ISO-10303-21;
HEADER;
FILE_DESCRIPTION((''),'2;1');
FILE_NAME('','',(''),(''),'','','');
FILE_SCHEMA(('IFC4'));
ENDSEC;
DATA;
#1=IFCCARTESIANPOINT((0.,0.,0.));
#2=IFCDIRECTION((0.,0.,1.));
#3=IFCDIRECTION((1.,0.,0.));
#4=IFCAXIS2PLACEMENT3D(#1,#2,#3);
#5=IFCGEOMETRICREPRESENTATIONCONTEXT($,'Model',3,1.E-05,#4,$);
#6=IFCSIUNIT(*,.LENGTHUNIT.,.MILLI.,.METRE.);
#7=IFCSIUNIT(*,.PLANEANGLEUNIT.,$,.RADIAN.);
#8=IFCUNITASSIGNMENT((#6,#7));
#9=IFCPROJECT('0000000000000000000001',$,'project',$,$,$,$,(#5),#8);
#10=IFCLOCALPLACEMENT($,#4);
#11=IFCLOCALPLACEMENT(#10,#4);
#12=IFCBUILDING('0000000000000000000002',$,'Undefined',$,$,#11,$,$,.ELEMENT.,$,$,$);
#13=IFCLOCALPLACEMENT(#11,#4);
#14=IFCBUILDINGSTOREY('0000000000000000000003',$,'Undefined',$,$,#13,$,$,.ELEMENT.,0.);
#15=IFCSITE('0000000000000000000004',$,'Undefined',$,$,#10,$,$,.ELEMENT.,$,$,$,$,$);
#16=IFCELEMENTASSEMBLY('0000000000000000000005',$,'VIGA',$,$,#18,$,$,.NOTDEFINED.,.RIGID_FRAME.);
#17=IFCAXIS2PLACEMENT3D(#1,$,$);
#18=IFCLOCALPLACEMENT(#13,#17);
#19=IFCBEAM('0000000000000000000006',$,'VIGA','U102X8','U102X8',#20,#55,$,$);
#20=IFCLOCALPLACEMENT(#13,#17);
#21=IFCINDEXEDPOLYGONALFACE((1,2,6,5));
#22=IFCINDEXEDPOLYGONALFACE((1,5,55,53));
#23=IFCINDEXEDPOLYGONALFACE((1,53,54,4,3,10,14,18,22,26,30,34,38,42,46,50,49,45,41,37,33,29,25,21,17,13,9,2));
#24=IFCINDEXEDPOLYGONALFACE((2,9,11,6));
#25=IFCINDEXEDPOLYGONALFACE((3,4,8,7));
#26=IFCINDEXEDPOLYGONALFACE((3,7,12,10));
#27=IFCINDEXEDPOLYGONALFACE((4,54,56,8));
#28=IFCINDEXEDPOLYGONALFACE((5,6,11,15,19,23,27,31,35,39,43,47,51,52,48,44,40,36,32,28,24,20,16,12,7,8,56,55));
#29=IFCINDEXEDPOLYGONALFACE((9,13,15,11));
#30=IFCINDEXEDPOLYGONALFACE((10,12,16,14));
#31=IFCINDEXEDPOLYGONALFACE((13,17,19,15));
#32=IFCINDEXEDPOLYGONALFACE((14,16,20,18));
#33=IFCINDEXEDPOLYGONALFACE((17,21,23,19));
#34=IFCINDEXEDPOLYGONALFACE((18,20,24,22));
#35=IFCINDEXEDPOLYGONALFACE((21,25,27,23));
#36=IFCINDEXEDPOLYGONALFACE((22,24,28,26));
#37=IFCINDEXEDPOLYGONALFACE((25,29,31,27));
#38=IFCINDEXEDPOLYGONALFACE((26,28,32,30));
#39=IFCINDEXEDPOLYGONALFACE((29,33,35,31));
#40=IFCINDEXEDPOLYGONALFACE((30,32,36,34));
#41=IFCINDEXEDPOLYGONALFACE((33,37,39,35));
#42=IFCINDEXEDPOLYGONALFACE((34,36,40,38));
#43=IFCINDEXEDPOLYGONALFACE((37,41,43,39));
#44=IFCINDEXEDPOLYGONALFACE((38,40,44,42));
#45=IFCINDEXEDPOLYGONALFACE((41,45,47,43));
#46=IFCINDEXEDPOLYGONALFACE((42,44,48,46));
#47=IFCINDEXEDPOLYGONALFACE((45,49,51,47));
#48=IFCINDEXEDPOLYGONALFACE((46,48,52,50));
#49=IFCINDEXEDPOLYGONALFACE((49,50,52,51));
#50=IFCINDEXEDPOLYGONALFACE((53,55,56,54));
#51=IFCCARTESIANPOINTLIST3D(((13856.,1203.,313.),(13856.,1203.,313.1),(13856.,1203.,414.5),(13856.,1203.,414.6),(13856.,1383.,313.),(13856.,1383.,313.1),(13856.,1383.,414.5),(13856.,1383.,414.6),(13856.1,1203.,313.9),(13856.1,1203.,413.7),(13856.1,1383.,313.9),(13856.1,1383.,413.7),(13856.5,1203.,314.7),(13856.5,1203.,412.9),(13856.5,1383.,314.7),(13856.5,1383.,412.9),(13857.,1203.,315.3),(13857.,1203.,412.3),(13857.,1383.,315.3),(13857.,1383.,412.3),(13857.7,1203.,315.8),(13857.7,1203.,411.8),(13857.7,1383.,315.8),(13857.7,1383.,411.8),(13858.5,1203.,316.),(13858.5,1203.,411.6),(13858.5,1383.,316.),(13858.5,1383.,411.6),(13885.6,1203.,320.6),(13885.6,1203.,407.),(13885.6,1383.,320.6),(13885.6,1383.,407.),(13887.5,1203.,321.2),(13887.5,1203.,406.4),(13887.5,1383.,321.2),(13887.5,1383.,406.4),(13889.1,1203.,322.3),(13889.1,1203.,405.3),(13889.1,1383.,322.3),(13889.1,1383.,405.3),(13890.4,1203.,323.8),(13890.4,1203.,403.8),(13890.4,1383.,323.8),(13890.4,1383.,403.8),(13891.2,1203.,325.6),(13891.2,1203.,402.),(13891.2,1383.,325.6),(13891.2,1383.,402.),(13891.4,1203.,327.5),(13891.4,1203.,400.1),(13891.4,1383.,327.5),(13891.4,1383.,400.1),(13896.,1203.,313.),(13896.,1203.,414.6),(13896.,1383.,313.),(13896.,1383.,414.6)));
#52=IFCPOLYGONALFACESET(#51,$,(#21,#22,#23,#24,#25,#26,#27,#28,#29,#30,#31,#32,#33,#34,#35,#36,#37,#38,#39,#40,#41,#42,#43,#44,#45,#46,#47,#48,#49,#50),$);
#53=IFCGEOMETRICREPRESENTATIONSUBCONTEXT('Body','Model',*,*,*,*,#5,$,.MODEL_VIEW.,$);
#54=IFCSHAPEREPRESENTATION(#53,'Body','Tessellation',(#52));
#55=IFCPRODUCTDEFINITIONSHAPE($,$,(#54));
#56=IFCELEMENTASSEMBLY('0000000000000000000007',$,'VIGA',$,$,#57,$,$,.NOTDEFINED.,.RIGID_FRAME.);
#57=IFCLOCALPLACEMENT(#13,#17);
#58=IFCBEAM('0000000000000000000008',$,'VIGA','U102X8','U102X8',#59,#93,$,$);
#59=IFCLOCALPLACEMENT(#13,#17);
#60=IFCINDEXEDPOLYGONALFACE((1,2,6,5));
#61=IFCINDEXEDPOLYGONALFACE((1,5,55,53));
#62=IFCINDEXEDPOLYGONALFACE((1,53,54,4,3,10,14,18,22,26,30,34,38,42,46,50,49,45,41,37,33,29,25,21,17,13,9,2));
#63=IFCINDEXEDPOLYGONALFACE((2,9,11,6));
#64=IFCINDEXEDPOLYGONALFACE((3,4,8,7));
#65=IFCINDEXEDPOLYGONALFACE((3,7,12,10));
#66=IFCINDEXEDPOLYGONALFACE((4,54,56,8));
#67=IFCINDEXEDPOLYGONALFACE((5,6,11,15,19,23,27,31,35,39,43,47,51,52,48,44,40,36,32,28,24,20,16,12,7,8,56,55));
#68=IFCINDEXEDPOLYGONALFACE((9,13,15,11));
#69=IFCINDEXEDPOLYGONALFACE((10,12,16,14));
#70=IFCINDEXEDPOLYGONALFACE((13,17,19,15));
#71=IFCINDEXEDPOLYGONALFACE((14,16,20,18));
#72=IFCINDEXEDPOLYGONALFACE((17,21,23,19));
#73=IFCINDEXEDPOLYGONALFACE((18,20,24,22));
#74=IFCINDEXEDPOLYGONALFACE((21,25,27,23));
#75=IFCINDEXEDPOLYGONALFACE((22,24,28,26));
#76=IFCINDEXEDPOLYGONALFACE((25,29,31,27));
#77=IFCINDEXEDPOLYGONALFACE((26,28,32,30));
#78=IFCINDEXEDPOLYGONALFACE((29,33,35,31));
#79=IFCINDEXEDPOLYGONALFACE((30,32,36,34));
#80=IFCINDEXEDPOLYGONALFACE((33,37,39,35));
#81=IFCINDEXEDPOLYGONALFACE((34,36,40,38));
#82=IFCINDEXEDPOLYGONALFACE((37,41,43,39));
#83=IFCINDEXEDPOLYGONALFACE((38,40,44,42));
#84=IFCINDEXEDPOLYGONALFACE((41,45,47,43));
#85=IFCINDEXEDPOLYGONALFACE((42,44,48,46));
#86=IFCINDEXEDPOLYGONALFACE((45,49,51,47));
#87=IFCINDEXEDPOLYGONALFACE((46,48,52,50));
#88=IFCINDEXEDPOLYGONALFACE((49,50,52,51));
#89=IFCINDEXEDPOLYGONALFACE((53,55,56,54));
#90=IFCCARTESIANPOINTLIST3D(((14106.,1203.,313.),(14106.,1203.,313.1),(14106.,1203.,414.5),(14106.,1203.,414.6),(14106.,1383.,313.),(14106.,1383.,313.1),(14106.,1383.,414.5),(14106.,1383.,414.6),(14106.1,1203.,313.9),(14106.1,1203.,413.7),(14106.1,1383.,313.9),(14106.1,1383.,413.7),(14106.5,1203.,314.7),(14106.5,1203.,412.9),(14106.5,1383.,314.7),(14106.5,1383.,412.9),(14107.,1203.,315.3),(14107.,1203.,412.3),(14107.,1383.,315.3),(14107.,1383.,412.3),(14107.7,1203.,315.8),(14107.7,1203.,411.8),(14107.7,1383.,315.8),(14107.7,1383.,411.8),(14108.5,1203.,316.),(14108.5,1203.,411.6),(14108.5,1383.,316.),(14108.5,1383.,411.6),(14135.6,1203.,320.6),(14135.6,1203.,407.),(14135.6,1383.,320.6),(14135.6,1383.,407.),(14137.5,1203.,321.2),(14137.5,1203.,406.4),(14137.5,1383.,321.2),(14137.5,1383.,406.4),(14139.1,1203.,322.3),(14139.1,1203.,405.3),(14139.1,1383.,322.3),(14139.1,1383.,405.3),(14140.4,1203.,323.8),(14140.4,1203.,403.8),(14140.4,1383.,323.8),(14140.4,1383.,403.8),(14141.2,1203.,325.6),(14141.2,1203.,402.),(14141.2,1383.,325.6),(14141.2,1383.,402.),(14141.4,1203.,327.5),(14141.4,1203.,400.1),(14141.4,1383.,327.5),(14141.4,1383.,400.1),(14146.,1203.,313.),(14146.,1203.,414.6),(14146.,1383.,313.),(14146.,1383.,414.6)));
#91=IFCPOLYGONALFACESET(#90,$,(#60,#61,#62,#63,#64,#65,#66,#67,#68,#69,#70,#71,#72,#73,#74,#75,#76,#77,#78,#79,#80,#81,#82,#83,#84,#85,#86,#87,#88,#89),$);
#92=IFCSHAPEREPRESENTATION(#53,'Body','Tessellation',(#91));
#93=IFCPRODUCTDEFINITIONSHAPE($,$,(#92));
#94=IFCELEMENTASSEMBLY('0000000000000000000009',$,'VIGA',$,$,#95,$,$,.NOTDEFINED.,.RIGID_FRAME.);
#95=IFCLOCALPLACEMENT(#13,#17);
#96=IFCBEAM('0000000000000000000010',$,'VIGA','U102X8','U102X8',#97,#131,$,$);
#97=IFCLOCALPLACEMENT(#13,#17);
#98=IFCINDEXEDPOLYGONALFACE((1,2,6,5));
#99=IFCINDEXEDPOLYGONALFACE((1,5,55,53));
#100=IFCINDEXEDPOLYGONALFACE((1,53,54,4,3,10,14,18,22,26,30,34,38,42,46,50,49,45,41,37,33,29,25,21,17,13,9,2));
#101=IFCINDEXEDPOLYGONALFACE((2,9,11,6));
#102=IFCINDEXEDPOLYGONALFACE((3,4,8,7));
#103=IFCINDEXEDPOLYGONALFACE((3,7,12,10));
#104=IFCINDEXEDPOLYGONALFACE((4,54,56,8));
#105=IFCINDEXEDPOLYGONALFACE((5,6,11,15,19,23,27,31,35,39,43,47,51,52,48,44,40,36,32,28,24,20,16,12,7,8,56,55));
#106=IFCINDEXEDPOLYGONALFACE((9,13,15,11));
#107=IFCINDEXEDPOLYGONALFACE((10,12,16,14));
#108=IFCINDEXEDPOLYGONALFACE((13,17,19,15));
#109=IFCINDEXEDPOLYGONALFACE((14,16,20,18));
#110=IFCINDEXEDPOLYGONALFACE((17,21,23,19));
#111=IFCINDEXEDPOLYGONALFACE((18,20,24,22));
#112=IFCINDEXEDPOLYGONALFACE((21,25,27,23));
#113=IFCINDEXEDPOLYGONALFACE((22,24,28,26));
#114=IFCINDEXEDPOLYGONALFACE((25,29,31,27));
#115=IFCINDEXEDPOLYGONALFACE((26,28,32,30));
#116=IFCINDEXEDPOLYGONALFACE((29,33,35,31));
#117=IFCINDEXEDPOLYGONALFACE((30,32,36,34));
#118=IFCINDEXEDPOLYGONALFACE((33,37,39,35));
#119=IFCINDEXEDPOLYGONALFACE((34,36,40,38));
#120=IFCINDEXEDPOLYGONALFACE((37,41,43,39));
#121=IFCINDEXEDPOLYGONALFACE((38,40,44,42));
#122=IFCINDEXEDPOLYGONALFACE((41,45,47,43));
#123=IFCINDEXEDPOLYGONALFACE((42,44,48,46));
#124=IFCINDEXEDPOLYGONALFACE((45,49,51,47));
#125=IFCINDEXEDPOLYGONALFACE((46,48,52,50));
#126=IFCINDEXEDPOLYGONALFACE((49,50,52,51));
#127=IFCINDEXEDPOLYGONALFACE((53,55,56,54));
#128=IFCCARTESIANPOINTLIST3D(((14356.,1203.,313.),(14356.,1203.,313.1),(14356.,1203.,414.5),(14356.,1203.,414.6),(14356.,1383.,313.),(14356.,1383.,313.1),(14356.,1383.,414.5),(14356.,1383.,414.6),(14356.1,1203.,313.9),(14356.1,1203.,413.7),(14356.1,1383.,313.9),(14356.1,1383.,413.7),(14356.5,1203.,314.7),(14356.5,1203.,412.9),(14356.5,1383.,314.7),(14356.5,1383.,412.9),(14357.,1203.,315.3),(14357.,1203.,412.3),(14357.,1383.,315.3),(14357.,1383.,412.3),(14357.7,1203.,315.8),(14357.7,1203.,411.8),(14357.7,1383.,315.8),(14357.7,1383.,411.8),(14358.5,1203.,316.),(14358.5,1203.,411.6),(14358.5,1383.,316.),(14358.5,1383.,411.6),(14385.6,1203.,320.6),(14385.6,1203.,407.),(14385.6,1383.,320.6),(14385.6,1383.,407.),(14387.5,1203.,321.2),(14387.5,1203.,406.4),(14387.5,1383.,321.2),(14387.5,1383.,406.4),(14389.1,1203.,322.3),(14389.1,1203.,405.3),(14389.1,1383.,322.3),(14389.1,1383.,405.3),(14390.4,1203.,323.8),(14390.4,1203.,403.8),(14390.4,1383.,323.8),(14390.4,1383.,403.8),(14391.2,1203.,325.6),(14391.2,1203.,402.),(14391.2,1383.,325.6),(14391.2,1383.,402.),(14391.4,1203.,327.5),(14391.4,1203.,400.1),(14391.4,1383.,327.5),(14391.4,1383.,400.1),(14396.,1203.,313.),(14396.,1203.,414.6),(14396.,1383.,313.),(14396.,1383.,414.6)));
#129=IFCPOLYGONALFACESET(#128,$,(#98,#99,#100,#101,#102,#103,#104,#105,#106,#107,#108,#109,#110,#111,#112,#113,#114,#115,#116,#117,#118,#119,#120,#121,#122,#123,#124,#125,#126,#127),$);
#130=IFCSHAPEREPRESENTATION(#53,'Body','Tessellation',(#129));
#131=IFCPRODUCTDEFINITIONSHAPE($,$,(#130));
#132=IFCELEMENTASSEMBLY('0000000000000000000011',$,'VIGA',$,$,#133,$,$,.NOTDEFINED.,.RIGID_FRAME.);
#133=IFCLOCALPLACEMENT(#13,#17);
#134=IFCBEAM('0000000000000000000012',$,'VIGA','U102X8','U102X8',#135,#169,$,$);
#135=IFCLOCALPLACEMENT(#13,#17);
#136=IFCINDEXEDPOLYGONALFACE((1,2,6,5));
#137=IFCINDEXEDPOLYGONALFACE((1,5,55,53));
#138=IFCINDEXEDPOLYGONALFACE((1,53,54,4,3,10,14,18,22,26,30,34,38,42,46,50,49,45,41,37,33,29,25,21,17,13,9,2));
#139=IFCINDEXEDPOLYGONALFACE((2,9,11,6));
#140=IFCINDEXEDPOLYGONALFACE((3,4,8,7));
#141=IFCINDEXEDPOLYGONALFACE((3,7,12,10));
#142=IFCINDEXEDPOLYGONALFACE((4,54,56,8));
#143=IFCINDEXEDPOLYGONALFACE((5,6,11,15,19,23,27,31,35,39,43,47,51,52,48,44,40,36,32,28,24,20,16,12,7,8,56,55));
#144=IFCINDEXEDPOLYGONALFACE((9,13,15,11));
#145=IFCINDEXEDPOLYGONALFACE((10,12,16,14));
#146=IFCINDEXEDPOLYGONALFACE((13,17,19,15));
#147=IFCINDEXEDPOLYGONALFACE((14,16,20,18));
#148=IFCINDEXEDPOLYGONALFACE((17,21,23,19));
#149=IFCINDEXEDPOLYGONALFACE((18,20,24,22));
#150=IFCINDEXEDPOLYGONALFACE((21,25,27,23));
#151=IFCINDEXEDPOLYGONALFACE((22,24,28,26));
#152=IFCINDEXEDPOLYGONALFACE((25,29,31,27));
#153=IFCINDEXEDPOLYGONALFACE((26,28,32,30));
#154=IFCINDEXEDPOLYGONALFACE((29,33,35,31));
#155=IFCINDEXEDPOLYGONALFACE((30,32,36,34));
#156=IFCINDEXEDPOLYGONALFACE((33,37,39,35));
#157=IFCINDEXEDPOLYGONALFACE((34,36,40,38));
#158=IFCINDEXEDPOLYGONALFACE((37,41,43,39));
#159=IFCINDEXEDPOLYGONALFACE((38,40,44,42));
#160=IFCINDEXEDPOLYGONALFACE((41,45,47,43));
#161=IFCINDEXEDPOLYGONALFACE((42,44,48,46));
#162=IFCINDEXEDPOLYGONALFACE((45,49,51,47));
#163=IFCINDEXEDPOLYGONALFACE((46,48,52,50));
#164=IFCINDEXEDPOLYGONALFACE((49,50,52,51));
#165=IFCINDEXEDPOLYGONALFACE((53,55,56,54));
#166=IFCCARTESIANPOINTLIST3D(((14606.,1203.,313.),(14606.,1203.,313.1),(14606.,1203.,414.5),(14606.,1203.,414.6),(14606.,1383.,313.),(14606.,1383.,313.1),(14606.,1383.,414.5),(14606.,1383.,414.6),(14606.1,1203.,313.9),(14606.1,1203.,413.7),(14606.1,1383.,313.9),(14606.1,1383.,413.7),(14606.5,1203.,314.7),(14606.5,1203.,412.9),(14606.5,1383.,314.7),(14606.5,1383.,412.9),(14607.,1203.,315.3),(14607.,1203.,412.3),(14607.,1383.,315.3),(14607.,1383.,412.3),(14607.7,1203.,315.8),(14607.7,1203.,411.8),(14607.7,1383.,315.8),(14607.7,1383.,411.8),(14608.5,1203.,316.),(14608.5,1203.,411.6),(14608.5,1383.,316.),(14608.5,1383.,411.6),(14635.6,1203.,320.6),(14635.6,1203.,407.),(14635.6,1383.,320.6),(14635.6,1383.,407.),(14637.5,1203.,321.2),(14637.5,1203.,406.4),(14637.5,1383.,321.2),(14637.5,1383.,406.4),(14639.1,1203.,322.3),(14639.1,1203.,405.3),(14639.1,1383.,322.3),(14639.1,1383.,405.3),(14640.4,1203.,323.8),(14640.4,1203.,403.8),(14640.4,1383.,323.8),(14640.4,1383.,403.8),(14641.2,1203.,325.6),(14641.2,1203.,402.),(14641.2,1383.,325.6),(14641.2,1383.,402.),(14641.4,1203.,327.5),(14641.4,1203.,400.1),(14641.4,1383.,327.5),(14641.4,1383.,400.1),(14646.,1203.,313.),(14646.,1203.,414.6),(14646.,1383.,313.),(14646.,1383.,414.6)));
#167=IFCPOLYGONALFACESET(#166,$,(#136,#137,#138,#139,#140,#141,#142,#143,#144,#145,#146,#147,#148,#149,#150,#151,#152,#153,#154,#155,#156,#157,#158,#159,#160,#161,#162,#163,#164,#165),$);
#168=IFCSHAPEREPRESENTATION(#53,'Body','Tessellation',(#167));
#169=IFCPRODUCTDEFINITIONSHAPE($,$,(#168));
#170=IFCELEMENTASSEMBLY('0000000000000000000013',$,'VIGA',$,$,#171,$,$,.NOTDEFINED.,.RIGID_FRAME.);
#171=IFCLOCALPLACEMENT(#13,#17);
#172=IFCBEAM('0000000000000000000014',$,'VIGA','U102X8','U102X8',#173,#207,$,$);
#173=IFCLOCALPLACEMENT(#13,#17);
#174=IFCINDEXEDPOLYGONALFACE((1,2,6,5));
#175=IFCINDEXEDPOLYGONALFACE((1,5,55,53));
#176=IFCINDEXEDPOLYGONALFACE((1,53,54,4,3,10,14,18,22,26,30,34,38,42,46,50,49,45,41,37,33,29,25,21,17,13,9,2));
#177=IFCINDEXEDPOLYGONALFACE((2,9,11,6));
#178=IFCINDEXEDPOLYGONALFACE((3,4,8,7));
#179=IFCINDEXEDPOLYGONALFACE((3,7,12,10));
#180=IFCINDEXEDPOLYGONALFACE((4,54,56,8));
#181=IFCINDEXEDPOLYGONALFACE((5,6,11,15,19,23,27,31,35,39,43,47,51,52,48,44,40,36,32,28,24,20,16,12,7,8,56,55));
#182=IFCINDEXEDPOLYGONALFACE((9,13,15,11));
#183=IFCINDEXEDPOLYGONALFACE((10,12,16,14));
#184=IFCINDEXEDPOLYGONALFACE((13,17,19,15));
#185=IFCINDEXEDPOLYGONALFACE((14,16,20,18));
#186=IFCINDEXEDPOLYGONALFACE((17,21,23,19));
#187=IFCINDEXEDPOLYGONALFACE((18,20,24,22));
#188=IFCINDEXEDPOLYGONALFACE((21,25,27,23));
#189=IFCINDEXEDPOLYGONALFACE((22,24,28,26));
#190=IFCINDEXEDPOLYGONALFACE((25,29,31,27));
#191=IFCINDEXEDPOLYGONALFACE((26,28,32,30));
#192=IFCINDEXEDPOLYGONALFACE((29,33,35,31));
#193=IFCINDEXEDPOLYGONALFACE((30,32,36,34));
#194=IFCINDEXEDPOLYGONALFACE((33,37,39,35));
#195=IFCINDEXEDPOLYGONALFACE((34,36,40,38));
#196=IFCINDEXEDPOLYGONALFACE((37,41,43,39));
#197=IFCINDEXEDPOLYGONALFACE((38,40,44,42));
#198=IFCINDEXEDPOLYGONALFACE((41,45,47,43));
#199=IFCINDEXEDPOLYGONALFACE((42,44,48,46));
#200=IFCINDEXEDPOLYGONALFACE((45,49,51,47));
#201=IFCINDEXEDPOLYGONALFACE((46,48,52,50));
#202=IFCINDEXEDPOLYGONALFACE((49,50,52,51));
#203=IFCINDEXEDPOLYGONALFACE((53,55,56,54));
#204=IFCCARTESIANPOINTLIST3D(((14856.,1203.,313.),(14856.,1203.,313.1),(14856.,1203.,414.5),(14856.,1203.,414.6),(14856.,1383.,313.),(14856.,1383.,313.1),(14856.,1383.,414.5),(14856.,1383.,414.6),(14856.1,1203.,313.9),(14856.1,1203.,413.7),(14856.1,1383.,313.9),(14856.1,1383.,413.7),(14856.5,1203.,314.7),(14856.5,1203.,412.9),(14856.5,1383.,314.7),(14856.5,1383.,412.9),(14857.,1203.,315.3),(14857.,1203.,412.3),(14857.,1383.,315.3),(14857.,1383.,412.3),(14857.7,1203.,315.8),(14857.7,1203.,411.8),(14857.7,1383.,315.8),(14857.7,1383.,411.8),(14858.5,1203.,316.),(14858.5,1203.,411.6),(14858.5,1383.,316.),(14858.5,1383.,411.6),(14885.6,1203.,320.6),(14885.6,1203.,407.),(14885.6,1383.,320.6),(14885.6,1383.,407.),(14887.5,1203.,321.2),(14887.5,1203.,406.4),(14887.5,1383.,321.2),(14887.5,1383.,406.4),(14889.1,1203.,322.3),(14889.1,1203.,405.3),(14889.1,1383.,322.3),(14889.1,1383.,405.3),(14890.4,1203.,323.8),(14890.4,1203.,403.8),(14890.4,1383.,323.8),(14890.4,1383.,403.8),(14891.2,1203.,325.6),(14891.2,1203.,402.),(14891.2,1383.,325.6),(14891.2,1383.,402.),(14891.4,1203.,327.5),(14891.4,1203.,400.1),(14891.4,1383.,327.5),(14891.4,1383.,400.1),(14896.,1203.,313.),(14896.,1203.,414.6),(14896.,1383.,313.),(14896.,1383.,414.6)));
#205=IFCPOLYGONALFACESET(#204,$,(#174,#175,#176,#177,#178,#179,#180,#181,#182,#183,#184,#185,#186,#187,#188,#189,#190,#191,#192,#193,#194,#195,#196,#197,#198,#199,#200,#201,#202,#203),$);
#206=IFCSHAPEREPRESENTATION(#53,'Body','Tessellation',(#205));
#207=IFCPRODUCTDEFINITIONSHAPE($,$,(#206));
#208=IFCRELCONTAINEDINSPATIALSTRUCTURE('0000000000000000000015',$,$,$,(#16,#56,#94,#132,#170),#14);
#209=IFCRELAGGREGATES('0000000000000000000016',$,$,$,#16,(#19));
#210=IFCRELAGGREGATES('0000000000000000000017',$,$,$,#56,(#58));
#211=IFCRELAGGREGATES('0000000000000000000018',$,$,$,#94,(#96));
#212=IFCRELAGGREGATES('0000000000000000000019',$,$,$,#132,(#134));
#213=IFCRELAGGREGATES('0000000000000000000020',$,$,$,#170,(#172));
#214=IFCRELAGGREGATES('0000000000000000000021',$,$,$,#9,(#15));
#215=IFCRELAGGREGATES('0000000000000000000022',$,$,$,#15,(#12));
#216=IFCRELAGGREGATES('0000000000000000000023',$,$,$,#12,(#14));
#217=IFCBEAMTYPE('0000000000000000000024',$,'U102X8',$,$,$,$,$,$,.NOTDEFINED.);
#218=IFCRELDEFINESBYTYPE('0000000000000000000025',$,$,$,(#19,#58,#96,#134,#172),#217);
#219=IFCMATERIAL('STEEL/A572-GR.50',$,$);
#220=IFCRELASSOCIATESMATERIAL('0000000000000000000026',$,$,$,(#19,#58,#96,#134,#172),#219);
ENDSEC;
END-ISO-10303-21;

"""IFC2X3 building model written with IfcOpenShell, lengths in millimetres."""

from ifc_helpers import new_model, si_unit, frame, origin_with_axes, origin_2d_with_axis, place, context, subcontext, project, spatial, u_section, extrude, material, type_object, element, aggregate, save


model = new_model("IFC2X3")

# Units and contexts
model_context = context("Model", 3, precision=1e-05, world=origin_with_axes())
body_context = subcontext(model_context, "Body", "Model", "MODEL_VIEW")
ifc_project = project(units=[si_unit("LENGTHUNIT", "METRE", prefix="MILLI"), si_unit("PLANEANGLEUNIT", "RADIAN")], contexts=[model_context])

# Site, building, storey
site_placement = place(None, origin_with_axes())
site = spatial("IfcSite", under=ifc_project, at=site_placement, Name="Undefined", CompositionType="ELEMENT")
building_placement = place(site_placement, origin_with_axes())
building = spatial("IfcBuilding", under=site, at=building_placement, Name="Undefined", CompositionType="ELEMENT")
storey_placement = place(building_placement, origin_with_axes())
storey = spatial("IfcBuildingStorey", under=building, at=storey_placement, Name="Undefined", CompositionType="ELEMENT", Elevation=0.0)

# Element assemblies, beams
assembly_1_placement = place(storey_placement, origin_with_axes())
assembly_1 = element("IfcElementAssembly", 1, at=assembly_1_placement, inside=storey, Name="VIGA", AssemblyPlace="NOTDEFINED", PredefinedType="RIGID_FRAME")
ifc_material = material(Name="STEEL/A572-GR.50")
beam_type = type_object("IfcBeamType", Name="U102X8", PredefinedType="NOTDEFINED")
beam_1_placement = place(assembly_1_placement, frame((13876.0, 1383.0, 363.8), z_axis=(0.0, 0.0, 1.0), x_axis=(0.0, -1.0, 0.0)))
beam_1 = element("IfcBeam", 2, at=beam_1_placement, type_object=beam_type, material=ifc_material, Name="VIGA", Description="U102X8", ObjectType="U102X8", context=body_context, shape_type="SweptSolid", body=[
    extrude(u_section(Depth=101.6, FlangeWidth=40.0, WebThickness=4.6, FlangeThickness=6.0, FilletRadius=7.0, EdgeRadius=3.0, FlangeSlope=0.16839, at=origin_2d_with_axis()), frame((180.0, 0.0, 0.0), z_axis=(-1.0, 0.0, 0.0), x_axis=(0.0, -1.0, 0.0)), (0.0, 0.0, 1.0), 180.0),
])
aggregate(assembly_1, [beam_1])
assembly_2_placement = place(storey_placement, origin_with_axes())
assembly_2 = element("IfcElementAssembly", 3, at=assembly_2_placement, inside=storey, Name="VIGA", AssemblyPlace="NOTDEFINED", PredefinedType="RIGID_FRAME")
beam_2_placement = place(assembly_2_placement, frame((14126.0, 1383.0, 363.8), z_axis=(0.0, 0.0, 1.0), x_axis=(0.0, -1.0, 0.0)))
beam_2 = element("IfcBeam", 4, at=beam_2_placement, type_object=beam_type, material=ifc_material, Name="VIGA", Description="U102X8", ObjectType="U102X8", context=body_context, shape_type="SweptSolid", body=[
    extrude(u_section(Depth=101.6, FlangeWidth=40.0, WebThickness=4.6, FlangeThickness=6.0, FilletRadius=7.0, EdgeRadius=3.0, FlangeSlope=0.16839, at=origin_2d_with_axis()), frame((180.0, 0.0, 0.0), z_axis=(-1.0, 0.0, 0.0), x_axis=(0.0, -1.0, 0.0)), (0.0, 0.0, 1.0), 180.0),
])
aggregate(assembly_2, [beam_2])
assembly_3_placement = place(storey_placement, origin_with_axes())
assembly_3 = element("IfcElementAssembly", 5, at=assembly_3_placement, inside=storey, Name="VIGA", AssemblyPlace="NOTDEFINED", PredefinedType="RIGID_FRAME")
beam_3_placement = place(assembly_3_placement, frame((14376.0, 1383.0, 363.8), z_axis=(0.0, 0.0, 1.0), x_axis=(0.0, -1.0, 0.0)))
beam_3 = element("IfcBeam", 6, at=beam_3_placement, type_object=beam_type, material=ifc_material, Name="VIGA", Description="U102X8", ObjectType="U102X8", context=body_context, shape_type="SweptSolid", body=[
    extrude(u_section(Depth=101.6, FlangeWidth=40.0, WebThickness=4.6, FlangeThickness=6.0, FilletRadius=7.0, EdgeRadius=3.0, FlangeSlope=0.16839, at=origin_2d_with_axis()), frame((180.0, 0.0, 0.0), z_axis=(-1.0, 0.0, 0.0), x_axis=(0.0, -1.0, 0.0)), (0.0, 0.0, 1.0), 180.0),
])
aggregate(assembly_3, [beam_3])
assembly_4_placement = place(storey_placement, origin_with_axes())
assembly_4 = element("IfcElementAssembly", 7, at=assembly_4_placement, inside=storey, Name="VIGA", AssemblyPlace="NOTDEFINED", PredefinedType="RIGID_FRAME")
beam_4_placement = place(assembly_4_placement, frame((14626.0, 1383.0, 363.8), z_axis=(0.0, 0.0, 1.0), x_axis=(0.0, -1.0, 0.0)))
beam_4 = element("IfcBeam", 8, at=beam_4_placement, type_object=beam_type, material=ifc_material, Name="VIGA", Description="U102X8", ObjectType="U102X8", context=body_context, shape_type="SweptSolid", body=[
    extrude(u_section(Depth=101.6, FlangeWidth=40.0, WebThickness=4.6, FlangeThickness=6.0, FilletRadius=7.0, EdgeRadius=3.0, FlangeSlope=0.16839, at=origin_2d_with_axis()), frame((180.0, 0.0, 0.0), z_axis=(-1.0, 0.0, 0.0), x_axis=(0.0, -1.0, 0.0)), (0.0, 0.0, 1.0), 180.0),
])
aggregate(assembly_4, [beam_4])
assembly_5_placement = place(storey_placement, origin_with_axes())
assembly_5 = element("IfcElementAssembly", 9, at=assembly_5_placement, inside=storey, Name="VIGA", AssemblyPlace="NOTDEFINED", PredefinedType="RIGID_FRAME")
beam_5_placement = place(assembly_5_placement, frame((14876.0, 1383.0, 363.8), z_axis=(0.0, 0.0, 1.0), x_axis=(0.0, -1.0, 0.0)))
beam_5 = element("IfcBeam", 10, at=beam_5_placement, type_object=beam_type, material=ifc_material, Name="VIGA", Description="U102X8", ObjectType="U102X8", context=body_context, shape_type="SweptSolid", body=[
    extrude(u_section(Depth=101.6, FlangeWidth=40.0, WebThickness=4.6, FlangeThickness=6.0, FilletRadius=7.0, EdgeRadius=3.0, FlangeSlope=0.16839, at=origin_2d_with_axis()), frame((180.0, 0.0, 0.0), z_axis=(-1.0, 0.0, 0.0), x_axis=(0.0, -1.0, 0.0)), (0.0, 0.0, 1.0), 180.0),
])
aggregate(assembly_5, [beam_5])

save(model, "model.ifc")
